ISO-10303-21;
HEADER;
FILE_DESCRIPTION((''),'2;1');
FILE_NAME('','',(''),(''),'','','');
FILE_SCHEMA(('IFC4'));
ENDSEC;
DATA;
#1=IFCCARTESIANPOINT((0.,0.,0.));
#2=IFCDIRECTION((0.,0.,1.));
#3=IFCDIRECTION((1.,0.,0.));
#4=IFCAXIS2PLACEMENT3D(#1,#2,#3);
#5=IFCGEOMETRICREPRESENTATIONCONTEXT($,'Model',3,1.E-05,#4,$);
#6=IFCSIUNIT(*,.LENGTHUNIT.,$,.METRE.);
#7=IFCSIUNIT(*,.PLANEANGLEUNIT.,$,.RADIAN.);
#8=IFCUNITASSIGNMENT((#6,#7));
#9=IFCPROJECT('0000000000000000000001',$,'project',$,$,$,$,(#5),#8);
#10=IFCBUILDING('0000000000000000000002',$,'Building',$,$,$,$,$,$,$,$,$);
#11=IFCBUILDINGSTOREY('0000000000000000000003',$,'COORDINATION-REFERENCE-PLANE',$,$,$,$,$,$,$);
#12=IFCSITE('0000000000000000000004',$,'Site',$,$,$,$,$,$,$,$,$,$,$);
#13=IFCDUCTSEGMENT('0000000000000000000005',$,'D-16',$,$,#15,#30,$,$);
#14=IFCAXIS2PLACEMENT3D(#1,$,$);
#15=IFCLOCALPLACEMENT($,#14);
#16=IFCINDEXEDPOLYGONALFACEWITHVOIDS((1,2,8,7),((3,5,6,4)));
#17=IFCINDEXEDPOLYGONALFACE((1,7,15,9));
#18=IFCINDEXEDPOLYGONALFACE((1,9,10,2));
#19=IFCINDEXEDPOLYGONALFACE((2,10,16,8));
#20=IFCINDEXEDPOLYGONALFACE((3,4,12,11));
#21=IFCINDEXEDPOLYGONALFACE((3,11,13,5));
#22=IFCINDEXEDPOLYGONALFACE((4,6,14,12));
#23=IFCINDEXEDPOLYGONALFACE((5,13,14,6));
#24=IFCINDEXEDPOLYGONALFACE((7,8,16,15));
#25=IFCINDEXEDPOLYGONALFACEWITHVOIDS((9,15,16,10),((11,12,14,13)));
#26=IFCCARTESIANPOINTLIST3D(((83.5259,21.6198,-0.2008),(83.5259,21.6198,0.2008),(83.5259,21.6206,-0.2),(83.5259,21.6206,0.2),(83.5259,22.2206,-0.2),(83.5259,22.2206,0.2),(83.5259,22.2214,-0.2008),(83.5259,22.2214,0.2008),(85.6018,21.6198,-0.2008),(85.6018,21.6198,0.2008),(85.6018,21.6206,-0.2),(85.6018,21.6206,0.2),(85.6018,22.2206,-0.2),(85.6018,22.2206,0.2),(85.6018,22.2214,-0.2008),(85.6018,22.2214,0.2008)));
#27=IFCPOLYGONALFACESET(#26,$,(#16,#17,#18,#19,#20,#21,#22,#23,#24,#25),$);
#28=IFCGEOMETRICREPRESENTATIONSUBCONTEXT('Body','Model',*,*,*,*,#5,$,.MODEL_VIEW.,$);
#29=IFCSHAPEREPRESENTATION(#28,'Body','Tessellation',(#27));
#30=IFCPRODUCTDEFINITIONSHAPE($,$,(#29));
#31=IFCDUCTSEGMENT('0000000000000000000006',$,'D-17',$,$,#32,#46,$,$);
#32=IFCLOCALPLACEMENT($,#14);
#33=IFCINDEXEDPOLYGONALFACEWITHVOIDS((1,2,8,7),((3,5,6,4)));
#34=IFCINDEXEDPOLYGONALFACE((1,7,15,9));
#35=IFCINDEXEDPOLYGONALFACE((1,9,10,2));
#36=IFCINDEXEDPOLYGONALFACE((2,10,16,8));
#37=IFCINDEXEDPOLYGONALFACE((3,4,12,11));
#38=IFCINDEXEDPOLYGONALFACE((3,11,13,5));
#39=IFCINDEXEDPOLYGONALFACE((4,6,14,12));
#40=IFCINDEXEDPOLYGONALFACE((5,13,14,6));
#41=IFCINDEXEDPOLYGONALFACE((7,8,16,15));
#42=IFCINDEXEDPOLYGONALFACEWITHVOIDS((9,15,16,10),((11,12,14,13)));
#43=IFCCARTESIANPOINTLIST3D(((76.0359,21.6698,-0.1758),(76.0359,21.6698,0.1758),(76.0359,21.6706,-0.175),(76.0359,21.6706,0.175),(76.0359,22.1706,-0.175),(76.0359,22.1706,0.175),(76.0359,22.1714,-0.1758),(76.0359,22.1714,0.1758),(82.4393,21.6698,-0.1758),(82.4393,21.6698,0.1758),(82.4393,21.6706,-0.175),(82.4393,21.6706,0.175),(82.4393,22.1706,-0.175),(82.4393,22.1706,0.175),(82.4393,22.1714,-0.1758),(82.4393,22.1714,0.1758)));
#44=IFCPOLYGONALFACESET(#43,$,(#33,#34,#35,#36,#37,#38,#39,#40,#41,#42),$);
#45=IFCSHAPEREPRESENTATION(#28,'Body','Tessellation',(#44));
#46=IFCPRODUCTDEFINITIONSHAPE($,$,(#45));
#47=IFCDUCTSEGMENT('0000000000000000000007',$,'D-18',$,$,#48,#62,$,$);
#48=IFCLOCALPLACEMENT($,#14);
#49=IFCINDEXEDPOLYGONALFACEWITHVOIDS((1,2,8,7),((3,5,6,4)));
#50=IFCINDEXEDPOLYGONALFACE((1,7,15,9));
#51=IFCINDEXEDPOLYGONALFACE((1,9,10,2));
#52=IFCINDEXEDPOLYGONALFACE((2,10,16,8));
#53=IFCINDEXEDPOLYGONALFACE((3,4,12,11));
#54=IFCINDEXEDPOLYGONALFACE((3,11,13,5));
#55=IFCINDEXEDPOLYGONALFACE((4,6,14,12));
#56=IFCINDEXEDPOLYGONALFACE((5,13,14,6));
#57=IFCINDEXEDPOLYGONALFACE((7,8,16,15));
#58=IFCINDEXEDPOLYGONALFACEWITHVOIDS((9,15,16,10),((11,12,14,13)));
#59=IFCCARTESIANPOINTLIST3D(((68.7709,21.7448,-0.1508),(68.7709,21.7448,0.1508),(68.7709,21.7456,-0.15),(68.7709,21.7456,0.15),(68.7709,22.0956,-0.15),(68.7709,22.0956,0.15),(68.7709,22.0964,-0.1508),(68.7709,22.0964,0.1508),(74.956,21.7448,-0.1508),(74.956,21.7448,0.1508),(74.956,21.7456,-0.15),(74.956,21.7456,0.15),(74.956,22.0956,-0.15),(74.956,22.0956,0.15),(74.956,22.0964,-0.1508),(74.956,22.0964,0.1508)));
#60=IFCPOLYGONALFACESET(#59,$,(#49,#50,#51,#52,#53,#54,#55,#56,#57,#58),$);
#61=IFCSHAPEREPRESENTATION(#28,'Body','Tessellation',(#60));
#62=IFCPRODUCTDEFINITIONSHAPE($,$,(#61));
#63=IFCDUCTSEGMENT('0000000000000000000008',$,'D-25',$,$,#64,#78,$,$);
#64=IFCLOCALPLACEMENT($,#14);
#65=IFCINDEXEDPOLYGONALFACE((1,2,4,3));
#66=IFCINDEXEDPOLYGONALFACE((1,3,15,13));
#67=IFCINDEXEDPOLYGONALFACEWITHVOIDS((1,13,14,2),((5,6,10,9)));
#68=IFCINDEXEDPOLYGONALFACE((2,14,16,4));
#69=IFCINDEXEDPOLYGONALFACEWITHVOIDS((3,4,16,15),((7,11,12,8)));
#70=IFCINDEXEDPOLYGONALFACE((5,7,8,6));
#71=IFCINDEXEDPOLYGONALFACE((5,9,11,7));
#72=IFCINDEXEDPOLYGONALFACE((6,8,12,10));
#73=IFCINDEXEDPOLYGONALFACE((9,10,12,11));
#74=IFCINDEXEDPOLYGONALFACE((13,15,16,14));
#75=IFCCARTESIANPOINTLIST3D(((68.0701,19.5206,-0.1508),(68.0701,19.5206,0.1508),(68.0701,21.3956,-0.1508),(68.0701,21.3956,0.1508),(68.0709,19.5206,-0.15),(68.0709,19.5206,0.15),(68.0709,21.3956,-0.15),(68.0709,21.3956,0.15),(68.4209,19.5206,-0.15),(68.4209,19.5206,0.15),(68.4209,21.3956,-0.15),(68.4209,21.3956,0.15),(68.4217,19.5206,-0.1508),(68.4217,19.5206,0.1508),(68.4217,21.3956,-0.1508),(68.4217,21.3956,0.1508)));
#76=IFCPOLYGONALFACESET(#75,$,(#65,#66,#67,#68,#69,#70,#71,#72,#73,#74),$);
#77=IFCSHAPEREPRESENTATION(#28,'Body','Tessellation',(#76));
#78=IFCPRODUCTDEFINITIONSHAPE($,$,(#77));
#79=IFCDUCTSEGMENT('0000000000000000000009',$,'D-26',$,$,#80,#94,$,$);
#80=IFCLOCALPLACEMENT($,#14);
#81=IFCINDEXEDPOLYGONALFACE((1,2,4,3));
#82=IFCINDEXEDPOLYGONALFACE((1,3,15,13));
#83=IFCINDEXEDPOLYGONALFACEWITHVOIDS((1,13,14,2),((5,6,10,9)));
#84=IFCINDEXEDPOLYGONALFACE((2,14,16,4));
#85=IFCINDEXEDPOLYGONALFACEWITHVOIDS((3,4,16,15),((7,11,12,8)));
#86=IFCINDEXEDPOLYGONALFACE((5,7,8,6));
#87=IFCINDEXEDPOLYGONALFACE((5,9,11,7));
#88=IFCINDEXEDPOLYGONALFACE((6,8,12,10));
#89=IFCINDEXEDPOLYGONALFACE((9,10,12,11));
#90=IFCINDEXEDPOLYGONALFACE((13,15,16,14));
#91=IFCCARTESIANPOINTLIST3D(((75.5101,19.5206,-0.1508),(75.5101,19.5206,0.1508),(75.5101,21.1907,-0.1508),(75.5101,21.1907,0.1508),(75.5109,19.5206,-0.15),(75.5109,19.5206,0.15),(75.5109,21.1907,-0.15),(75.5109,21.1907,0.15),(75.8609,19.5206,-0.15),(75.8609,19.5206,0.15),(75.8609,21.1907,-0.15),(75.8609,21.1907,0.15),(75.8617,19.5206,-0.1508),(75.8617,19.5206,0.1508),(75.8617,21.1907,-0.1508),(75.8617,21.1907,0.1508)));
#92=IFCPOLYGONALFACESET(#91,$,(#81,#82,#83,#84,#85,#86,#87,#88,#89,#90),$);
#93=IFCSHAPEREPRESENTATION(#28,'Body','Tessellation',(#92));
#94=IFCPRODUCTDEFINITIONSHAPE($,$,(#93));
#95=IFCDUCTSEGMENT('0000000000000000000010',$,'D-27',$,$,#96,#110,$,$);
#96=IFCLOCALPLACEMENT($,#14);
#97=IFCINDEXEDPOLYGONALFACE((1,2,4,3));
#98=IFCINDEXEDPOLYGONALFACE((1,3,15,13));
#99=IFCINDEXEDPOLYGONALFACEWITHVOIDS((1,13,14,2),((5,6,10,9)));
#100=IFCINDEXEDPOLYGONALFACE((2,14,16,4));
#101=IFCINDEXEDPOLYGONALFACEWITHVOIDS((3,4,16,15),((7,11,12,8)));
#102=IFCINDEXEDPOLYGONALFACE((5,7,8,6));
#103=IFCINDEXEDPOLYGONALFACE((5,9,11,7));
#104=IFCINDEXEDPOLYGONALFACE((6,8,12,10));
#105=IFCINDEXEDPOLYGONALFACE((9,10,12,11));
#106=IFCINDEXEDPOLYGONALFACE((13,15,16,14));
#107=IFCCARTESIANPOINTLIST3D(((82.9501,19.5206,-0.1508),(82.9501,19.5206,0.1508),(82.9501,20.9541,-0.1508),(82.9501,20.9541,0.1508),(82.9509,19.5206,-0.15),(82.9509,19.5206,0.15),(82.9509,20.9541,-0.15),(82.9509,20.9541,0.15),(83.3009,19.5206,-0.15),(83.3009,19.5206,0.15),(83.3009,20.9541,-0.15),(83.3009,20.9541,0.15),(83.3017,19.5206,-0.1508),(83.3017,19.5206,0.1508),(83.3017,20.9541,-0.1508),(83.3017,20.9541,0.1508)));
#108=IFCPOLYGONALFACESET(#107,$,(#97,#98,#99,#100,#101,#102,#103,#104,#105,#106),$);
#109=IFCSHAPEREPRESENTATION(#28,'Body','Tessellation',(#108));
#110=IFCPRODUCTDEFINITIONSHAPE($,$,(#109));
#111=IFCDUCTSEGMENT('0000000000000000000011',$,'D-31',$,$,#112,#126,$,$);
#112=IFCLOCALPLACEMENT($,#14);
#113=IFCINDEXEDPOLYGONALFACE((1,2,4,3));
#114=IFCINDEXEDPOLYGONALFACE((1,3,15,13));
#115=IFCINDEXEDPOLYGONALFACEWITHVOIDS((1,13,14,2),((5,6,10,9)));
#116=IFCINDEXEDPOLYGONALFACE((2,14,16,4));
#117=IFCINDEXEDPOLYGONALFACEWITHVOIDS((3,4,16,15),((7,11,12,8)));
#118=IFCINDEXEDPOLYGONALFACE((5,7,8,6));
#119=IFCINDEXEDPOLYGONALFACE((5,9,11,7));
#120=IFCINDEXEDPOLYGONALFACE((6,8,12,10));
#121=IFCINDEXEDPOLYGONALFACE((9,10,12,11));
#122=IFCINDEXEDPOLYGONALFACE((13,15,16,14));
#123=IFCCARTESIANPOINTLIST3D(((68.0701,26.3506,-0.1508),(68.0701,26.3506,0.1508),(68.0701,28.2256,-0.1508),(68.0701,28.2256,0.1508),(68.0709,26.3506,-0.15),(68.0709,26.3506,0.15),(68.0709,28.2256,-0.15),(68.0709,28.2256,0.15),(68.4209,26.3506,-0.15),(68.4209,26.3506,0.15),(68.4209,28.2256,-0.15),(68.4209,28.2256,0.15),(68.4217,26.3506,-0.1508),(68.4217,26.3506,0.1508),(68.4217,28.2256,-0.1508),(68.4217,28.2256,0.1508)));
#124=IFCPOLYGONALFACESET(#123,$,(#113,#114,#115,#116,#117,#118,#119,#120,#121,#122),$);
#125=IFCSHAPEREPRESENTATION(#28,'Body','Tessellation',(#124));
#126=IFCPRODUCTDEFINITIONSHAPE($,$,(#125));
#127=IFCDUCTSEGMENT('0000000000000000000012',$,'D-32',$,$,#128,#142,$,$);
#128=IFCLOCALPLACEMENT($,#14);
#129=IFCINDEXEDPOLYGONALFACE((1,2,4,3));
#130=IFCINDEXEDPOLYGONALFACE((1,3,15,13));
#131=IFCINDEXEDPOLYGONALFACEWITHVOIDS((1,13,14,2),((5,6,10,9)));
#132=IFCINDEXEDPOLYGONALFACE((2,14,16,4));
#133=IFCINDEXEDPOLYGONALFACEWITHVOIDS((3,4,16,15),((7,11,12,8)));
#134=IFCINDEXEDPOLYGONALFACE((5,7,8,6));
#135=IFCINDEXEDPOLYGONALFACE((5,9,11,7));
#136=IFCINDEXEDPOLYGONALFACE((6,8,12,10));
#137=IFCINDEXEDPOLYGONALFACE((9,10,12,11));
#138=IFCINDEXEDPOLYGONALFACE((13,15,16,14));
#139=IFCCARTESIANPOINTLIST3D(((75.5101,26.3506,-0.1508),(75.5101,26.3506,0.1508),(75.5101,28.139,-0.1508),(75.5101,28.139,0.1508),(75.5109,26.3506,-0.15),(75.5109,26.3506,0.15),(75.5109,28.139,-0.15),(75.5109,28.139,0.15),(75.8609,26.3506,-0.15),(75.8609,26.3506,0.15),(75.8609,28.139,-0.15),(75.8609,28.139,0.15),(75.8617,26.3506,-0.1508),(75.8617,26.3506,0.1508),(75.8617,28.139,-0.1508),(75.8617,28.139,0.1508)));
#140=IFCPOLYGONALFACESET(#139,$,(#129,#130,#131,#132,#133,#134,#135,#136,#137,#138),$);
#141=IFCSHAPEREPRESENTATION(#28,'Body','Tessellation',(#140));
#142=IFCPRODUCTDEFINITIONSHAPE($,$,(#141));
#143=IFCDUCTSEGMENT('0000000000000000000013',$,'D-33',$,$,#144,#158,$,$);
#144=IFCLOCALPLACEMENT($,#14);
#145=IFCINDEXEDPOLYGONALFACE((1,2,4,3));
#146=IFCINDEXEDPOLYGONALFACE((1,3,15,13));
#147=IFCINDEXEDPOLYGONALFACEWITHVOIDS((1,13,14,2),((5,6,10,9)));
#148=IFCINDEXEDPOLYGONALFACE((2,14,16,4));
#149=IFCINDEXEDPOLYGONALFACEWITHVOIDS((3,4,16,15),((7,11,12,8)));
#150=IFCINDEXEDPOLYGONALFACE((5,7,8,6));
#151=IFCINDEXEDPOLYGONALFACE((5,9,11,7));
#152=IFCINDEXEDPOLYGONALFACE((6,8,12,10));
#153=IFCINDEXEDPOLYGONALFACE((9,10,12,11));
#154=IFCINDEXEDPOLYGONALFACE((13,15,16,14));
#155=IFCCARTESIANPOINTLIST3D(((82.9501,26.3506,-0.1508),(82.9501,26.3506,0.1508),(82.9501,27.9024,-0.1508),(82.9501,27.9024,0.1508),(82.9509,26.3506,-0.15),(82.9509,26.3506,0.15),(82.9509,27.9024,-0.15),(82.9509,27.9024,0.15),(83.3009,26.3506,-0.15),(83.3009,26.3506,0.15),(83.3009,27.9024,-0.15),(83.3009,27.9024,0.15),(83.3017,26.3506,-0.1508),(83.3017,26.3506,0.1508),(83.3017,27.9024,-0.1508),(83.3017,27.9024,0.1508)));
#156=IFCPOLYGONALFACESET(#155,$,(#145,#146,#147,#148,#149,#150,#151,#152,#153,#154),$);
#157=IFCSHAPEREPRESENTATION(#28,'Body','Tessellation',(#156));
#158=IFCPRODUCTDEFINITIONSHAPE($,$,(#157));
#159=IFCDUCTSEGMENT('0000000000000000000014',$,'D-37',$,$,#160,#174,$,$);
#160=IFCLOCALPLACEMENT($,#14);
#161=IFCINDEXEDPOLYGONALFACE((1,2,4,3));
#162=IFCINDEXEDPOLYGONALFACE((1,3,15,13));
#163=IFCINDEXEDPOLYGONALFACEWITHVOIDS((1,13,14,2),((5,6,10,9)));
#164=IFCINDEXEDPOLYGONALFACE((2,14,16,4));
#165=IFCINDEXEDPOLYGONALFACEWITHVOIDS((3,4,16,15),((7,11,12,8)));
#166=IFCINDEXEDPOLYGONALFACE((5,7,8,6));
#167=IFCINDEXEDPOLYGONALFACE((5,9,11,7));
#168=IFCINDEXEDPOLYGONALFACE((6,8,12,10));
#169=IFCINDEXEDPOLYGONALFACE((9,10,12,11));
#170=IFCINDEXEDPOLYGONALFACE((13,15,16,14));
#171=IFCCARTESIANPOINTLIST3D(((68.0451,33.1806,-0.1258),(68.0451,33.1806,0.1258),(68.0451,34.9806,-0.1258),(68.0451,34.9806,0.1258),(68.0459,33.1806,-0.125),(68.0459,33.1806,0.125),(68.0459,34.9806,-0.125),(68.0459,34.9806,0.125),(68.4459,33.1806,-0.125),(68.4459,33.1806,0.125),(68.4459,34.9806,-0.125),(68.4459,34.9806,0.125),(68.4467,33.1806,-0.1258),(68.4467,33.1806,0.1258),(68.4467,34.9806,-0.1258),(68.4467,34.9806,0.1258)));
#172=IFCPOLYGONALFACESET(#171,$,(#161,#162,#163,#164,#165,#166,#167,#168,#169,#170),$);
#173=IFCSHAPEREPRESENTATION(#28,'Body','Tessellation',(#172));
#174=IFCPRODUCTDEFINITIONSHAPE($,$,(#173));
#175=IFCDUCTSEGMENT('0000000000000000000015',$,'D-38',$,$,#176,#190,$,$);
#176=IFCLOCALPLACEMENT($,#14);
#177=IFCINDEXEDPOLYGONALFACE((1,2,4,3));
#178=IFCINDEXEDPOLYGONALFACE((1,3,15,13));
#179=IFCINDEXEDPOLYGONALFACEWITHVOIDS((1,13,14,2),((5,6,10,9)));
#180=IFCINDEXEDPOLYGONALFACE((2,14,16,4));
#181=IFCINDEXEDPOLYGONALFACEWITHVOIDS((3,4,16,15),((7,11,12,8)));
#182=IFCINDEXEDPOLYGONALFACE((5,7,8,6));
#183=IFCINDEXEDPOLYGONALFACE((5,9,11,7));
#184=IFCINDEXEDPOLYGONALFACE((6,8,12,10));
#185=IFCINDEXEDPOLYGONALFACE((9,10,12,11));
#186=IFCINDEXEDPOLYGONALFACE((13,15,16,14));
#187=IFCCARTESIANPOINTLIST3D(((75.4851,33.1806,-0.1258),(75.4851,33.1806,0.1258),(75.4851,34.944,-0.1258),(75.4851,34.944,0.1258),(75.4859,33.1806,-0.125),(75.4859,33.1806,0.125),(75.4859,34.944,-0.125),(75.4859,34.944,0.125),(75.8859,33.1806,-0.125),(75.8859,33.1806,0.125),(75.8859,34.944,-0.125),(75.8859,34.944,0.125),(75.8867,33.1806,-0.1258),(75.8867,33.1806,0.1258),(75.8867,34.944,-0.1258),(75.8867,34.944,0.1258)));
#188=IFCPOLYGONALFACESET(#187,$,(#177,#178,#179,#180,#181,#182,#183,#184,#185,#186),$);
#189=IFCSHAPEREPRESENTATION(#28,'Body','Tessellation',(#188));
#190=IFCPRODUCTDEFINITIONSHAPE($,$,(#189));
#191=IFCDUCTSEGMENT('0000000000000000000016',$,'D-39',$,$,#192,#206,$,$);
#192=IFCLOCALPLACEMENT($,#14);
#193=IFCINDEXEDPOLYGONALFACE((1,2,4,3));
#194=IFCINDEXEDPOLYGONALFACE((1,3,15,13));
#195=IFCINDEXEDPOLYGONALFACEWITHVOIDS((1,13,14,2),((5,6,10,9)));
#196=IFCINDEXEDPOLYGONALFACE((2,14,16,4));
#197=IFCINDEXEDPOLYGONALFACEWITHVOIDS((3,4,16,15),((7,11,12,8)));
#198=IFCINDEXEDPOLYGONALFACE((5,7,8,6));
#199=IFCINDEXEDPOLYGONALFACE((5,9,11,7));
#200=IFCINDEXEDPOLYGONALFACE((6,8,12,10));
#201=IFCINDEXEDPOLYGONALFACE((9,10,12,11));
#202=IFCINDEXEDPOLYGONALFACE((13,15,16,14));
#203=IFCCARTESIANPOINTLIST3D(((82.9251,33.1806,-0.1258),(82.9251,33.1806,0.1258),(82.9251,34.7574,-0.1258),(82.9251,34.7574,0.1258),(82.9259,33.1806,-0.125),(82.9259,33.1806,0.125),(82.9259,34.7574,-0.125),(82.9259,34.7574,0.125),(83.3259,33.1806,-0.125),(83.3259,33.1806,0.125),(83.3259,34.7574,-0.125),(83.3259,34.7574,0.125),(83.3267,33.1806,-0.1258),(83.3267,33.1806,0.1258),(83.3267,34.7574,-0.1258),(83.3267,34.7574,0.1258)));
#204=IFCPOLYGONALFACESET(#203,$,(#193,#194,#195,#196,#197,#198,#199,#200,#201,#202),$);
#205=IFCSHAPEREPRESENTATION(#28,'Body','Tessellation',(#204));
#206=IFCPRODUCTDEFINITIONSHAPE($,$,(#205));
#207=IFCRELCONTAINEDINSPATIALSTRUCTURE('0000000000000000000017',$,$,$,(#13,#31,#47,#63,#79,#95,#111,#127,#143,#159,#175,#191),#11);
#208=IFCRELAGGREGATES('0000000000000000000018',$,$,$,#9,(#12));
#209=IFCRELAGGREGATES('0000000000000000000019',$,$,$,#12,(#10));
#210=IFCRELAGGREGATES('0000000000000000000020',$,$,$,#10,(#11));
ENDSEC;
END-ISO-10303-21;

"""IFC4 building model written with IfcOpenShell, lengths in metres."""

from ifc_helpers import new_model, si_unit, frame, origin, origin_with_axes, place, context, subcontext, project, spatial, hollow_rectangle, extrude, element, save


model = new_model("IFC4")

# Units and contexts
model_context = context("Model", 3, precision=1e-05, world=origin_with_axes())
body_context = subcontext(model_context, "Body", "Model", "MODEL_VIEW")
ifc_project = project(units=[si_unit("LENGTHUNIT", "METRE"), si_unit("PLANEANGLEUNIT", "RADIAN")], contexts=[model_context])

# Site, building, storey
site = spatial("IfcSite", under=ifc_project, Name="Site")
building = spatial("IfcBuilding", under=site, Name="Building")
storey = spatial("IfcBuildingStorey", under=building, Name="COORDINATION-REFERENCE-PLANE")

# Duct segments
duct_segment_1_placement = place(None, frame((83.5259, 21.9206, 0.0), z_axis=(1.0, 0.0, 0.0), x_axis=(0.0, 1.0, 0.0)))
element("IfcDuctSegment", 1, at=duct_segment_1_placement, inside=storey, Name="D-16", context=body_context, shape_type="SweptSolid", body=[
    extrude(hollow_rectangle(XDim=0.6016, YDim=0.4016, WallThickness=0.0008), origin(), (0.0, 0.0, 1.0), 2.0759),
])
duct_segment_2_placement = place(None, frame((76.0359, 21.9206, 0.0), z_axis=(1.0, 0.0, 0.0), x_axis=(0.0, 1.0, 0.0)))
element("IfcDuctSegment", 2, at=duct_segment_2_placement, inside=storey, Name="D-17", context=body_context, shape_type="SweptSolid", body=[
    extrude(hollow_rectangle(XDim=0.5016, YDim=0.3516, WallThickness=0.0008), origin(), (0.0, 0.0, 1.0), 6.4034),
])
duct_segment_3_placement = place(None, frame((68.7709, 21.9206, 0.0), z_axis=(1.0, 0.0, 0.0), x_axis=(0.0, 1.0, 0.0)))
element("IfcDuctSegment", 3, at=duct_segment_3_placement, inside=storey, Name="D-18", context=body_context, shape_type="SweptSolid", body=[
    extrude(hollow_rectangle(XDim=0.3516, YDim=0.3016, WallThickness=0.0008), origin(), (0.0, 0.0, 1.0), 6.1851),
])
duct_segment_4_placement = place(None, frame((68.2459, 19.5206, 0.0), z_axis=(0.0, 1.0, 0.0), x_axis=(1.0, 0.0, 0.0)))
element("IfcDuctSegment", 4, at=duct_segment_4_placement, inside=storey, Name="D-25", context=body_context, shape_type="SweptSolid", body=[
    extrude(hollow_rectangle(XDim=0.3516, YDim=0.3016, WallThickness=0.0008), origin(), (0.0, 0.0, 1.0), 1.875),
])
duct_segment_5_placement = place(None, frame((75.6859, 19.5206, 0.0), z_axis=(0.0, 1.0, 0.0), x_axis=(1.0, 0.0, 0.0)))
element("IfcDuctSegment", 5, at=duct_segment_5_placement, inside=storey, Name="D-26", context=body_context, shape_type="SweptSolid", body=[
    extrude(hollow_rectangle(XDim=0.3516, YDim=0.3016, WallThickness=0.0008), origin(), (0.0, 0.0, 1.0), 1.6701),
])
duct_segment_6_placement = place(None, frame((83.1259, 19.5206, 0.0), z_axis=(0.0, 1.0, 0.0), x_axis=(1.0, 0.0, 0.0)))
element("IfcDuctSegment", 6, at=duct_segment_6_placement, inside=storey, Name="D-27", context=body_context, shape_type="SweptSolid", body=[
    extrude(hollow_rectangle(XDim=0.3516, YDim=0.3016, WallThickness=0.0008), origin(), (0.0, 0.0, 1.0), 1.4335),
])
duct_segment_7_placement = place(None, frame((68.2459, 26.3506, 0.0), z_axis=(0.0, 1.0, 0.0), x_axis=(1.0, 0.0, 0.0)))
element("IfcDuctSegment", 7, at=duct_segment_7_placement, inside=storey, Name="D-31", context=body_context, shape_type="SweptSolid", body=[
    extrude(hollow_rectangle(XDim=0.3516, YDim=0.3016, WallThickness=0.0008), origin(), (0.0, 0.0, 1.0), 1.875),
])
duct_segment_8_placement = place(None, frame((75.6859, 26.3506, 0.0), z_axis=(0.0, 1.0, 0.0), x_axis=(1.0, 0.0, 0.0)))
element("IfcDuctSegment", 8, at=duct_segment_8_placement, inside=storey, Name="D-32", context=body_context, shape_type="SweptSolid", body=[
    extrude(hollow_rectangle(XDim=0.3516, YDim=0.3016, WallThickness=0.0008), origin(), (0.0, 0.0, 1.0), 1.7884),
])
duct_segment_9_placement = place(None, frame((83.1259, 26.3506, 0.0), z_axis=(0.0, 1.0, 0.0), x_axis=(1.0, 0.0, 0.0)))
element("IfcDuctSegment", 9, at=duct_segment_9_placement, inside=storey, Name="D-33", context=body_context, shape_type="SweptSolid", body=[
    extrude(hollow_rectangle(XDim=0.3516, YDim=0.3016, WallThickness=0.0008), origin(), (0.0, 0.0, 1.0), 1.5518),
])
duct_segment_10_placement = place(None, frame((68.2459, 33.1806, 0.0), z_axis=(0.0, 1.0, 0.0), x_axis=(1.0, 0.0, 0.0)))
element("IfcDuctSegment", 10, at=duct_segment_10_placement, inside=storey, Name="D-37", context=body_context, shape_type="SweptSolid", body=[
    extrude(hollow_rectangle(XDim=0.4016, YDim=0.2516, WallThickness=0.0008), origin(), (0.0, 0.0, 1.0), 1.8),
])
duct_segment_11_placement = place(None, frame((75.6859, 33.1806, 0.0), z_axis=(0.0, 1.0, 0.0), x_axis=(1.0, 0.0, 0.0)))
element("IfcDuctSegment", 11, at=duct_segment_11_placement, inside=storey, Name="D-38", context=body_context, shape_type="SweptSolid", body=[
    extrude(hollow_rectangle(XDim=0.4016, YDim=0.2516, WallThickness=0.0008), origin(), (0.0, 0.0, 1.0), 1.7634),
])
duct_segment_12_placement = place(None, frame((83.1259, 33.1806, 0.0), z_axis=(0.0, 1.0, 0.0), x_axis=(1.0, 0.0, 0.0)))
element("IfcDuctSegment", 12, at=duct_segment_12_placement, inside=storey, Name="D-39", context=body_context, shape_type="SweptSolid", body=[
    extrude(hollow_rectangle(XDim=0.4016, YDim=0.2516, WallThickness=0.0008), origin(), (0.0, 0.0, 1.0), 1.5768),
])

save(model, "model.ifc")
